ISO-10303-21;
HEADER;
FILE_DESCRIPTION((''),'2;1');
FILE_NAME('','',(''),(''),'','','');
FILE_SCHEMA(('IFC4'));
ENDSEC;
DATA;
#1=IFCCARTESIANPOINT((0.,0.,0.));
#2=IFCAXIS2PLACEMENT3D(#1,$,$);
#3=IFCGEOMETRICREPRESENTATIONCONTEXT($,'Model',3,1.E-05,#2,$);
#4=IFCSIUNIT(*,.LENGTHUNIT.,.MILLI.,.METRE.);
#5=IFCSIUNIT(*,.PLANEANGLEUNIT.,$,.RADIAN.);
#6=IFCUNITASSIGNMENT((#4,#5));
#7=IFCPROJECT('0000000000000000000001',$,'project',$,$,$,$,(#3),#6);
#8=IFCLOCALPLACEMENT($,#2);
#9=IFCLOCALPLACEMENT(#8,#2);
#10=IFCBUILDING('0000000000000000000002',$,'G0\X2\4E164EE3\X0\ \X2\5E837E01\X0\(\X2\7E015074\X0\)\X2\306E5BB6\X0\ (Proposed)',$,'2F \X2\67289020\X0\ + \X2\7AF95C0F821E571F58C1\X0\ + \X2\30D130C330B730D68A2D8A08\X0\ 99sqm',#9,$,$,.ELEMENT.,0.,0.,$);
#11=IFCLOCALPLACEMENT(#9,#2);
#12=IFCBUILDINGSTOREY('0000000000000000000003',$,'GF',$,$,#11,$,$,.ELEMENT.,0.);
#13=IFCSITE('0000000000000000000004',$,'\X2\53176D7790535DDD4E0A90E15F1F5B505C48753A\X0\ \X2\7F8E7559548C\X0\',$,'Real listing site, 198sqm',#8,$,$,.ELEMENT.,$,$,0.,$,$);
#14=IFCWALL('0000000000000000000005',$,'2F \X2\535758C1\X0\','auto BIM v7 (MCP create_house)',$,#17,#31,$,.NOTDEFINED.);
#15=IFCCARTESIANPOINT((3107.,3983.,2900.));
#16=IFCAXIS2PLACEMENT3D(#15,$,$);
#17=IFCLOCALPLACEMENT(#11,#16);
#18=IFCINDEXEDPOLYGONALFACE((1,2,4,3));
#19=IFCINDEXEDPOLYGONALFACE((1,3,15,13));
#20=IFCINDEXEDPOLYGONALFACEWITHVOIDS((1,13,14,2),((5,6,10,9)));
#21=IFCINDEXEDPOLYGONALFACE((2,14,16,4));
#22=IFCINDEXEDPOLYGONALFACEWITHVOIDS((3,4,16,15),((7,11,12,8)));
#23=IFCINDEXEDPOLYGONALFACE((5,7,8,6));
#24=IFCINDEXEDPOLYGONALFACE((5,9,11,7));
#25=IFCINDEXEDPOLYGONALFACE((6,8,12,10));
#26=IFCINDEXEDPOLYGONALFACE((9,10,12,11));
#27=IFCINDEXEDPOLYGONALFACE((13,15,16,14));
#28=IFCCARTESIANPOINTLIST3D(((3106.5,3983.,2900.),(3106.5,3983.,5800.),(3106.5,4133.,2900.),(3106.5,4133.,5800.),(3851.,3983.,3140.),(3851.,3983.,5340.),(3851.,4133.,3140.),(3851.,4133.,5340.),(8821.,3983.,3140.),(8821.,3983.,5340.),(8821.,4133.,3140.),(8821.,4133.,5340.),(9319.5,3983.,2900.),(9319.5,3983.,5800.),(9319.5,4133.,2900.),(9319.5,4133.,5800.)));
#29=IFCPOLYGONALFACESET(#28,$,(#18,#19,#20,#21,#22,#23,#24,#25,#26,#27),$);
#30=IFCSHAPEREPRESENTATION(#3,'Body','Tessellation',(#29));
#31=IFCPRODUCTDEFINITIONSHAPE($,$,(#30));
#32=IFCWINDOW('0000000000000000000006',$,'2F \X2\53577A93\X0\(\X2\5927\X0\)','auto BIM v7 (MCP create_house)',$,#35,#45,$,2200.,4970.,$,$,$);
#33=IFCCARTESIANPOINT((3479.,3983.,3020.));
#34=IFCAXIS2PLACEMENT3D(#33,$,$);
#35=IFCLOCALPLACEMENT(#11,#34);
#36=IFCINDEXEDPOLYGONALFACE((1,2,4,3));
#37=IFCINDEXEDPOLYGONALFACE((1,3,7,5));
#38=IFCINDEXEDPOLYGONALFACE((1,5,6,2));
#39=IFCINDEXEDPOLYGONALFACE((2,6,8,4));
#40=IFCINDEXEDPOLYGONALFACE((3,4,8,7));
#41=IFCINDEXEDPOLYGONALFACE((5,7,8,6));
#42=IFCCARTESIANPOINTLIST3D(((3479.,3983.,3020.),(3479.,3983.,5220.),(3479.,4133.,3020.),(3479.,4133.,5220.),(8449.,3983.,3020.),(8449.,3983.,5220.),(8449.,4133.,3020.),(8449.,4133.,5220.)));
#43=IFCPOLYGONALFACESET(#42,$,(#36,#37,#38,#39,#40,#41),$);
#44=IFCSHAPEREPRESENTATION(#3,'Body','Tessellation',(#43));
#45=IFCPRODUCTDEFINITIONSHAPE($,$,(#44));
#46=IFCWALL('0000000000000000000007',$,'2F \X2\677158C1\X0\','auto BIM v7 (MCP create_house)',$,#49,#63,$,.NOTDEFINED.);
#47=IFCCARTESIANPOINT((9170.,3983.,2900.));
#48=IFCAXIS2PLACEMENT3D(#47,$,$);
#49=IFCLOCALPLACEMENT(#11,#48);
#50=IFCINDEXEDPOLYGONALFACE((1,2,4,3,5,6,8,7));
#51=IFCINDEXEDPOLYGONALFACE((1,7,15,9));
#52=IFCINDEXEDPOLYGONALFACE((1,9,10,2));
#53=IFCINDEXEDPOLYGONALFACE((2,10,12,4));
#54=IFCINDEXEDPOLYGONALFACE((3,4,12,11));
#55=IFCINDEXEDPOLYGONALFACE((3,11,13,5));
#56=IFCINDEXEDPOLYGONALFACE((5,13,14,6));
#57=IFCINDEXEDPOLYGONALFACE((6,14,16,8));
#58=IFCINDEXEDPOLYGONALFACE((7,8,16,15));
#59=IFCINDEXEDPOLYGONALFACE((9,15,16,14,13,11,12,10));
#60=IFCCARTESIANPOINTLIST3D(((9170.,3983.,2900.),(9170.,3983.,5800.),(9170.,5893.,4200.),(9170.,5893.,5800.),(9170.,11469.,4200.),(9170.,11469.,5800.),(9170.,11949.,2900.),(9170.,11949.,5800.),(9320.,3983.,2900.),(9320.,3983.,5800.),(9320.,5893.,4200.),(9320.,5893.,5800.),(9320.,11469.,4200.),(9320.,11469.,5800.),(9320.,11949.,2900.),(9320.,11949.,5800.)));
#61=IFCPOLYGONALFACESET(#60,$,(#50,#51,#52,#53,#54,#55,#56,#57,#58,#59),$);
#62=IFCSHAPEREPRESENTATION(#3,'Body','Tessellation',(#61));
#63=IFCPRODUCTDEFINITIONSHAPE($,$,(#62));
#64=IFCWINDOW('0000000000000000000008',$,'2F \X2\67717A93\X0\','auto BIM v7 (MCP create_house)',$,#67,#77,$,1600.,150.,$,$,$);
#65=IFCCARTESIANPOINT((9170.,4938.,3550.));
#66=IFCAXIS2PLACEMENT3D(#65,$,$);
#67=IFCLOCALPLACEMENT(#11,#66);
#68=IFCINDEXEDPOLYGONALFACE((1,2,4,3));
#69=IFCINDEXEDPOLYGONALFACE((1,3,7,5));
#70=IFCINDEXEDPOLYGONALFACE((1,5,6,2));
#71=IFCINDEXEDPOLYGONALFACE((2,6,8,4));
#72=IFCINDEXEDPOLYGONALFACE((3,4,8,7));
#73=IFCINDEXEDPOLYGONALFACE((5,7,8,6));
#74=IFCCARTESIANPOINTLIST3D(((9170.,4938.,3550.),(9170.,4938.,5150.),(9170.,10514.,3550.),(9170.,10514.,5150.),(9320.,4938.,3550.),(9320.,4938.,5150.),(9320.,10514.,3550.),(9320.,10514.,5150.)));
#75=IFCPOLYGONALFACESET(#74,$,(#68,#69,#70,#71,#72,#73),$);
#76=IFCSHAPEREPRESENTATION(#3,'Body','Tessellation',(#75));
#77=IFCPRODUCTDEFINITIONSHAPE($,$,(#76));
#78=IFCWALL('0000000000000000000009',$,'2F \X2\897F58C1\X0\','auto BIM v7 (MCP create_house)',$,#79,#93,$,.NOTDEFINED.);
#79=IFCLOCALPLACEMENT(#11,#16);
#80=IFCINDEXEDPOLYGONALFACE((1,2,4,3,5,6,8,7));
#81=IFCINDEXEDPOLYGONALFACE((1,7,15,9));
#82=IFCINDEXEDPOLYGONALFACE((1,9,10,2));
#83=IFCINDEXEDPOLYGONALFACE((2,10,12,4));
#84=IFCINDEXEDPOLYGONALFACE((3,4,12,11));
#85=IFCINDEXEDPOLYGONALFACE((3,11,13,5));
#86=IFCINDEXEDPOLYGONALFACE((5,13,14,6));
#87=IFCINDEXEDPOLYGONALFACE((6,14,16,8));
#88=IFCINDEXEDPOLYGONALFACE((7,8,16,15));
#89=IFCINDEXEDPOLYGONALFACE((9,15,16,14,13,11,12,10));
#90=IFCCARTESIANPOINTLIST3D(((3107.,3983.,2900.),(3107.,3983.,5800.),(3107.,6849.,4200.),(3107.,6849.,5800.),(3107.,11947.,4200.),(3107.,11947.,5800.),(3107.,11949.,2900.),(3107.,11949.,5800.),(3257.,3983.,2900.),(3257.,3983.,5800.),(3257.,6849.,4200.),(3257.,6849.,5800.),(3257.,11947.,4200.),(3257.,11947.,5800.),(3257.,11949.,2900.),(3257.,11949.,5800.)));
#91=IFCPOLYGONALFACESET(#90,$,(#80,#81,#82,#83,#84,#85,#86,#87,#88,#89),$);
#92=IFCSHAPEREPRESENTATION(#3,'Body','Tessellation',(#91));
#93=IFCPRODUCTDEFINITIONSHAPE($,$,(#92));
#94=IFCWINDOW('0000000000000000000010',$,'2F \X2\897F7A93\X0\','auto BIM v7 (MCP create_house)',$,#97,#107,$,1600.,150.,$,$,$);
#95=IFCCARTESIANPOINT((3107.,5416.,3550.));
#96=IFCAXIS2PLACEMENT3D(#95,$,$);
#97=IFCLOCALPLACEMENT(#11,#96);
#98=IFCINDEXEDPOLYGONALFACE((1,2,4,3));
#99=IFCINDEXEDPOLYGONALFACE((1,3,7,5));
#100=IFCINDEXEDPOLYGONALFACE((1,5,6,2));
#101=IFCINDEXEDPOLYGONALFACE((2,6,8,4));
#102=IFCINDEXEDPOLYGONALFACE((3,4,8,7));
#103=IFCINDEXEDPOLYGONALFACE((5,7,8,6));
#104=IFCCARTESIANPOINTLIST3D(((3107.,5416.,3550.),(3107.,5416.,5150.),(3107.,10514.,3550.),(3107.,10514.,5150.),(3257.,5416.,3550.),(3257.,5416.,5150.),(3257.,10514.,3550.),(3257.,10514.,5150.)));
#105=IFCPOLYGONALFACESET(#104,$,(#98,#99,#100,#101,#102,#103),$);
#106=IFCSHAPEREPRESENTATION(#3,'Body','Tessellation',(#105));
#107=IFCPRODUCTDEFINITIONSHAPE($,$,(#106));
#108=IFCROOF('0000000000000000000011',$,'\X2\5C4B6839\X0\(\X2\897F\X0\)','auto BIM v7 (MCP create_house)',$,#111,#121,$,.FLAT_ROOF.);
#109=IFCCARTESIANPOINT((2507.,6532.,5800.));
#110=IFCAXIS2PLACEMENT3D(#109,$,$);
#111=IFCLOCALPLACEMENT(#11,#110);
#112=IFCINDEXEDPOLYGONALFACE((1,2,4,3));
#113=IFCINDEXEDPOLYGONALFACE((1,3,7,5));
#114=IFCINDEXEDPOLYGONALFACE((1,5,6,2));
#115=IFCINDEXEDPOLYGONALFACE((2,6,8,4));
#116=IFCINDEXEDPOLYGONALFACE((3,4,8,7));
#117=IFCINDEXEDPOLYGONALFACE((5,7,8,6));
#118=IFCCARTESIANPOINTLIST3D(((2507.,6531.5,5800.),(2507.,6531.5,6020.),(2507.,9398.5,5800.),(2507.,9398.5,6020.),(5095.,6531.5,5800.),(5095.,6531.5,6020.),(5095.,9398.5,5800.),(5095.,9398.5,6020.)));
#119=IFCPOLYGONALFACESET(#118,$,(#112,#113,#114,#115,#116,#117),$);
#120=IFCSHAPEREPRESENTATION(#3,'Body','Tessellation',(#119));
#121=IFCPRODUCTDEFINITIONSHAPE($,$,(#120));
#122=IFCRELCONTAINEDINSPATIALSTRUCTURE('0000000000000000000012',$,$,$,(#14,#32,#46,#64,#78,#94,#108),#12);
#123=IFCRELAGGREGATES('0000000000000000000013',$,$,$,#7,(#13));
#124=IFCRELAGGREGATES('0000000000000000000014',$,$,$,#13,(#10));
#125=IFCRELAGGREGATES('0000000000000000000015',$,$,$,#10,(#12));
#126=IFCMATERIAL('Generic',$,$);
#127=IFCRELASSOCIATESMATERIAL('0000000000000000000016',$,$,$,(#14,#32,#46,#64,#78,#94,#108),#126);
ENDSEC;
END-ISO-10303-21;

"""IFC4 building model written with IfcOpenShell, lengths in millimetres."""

from ifc_helpers import new_model, si_unit, frame, frame_2d, origin, place, context, project, spatial, rectangle, extrude, material, element, fill, save


model = new_model("IFC4")

# Units and contexts
model_context = context("Model", 3, precision=1e-05, world=origin())
ifc_project = project(units=[si_unit("LENGTHUNIT", "METRE", prefix="MILLI"), si_unit("PLANEANGLEUNIT", "RADIAN")], contexts=[model_context])

# Site, building, storey
site_placement = place(None, origin())
site = spatial("IfcSite", under=ifc_project, at=site_placement, Name="北海道川上郡弟子屈町 美留和", ObjectType="Real listing site, 198sqm", CompositionType="ELEMENT", RefElevation=0.0)
building_placement = place(site_placement, origin())
building = spatial("IfcBuilding", under=site, at=building_placement, Name="G0世代 広縁(縁側)の家 (Proposed)", ObjectType="2F 木造 + 竹小舞土壁 + パッシブ設計 99sqm", CompositionType="ELEMENT", ElevationOfRefHeight=0.0, ElevationOfTerrain=0.0)
storey_placement = place(building_placement, origin())
storey = spatial("IfcBuildingStorey", under=building, at=storey_placement, Name="GF", CompositionType="ELEMENT", Elevation=0.0)

# Shared definitions
ifc_material = material(Name="Generic")

# Walls, openings, windows
wall_1_placement = place(storey_placement, frame((3107.0, 3983.0, 2900.0)))
wall_1 = element("IfcWall", 1, at=wall_1_placement, inside=storey, material=ifc_material, Name="2F 南壁", Description="auto BIM v7 (MCP create_house)", PredefinedType="NOTDEFINED", context=model_context, shape_type="SweptSolid", body=[
    extrude(rectangle(XDim=6213.0, YDim=150.0, at=frame_2d((3106.0, 75.0))), frame((3107.0, 3983.0, 2900.0)), (0.0, 0.0, 1.0), 2900.0),
])
opening_1_placement = place(storey_placement, frame((3479.0, 3983.0, 3020.0)))
opening_1 = element("IfcOpeningElement", 2, at=opening_1_placement, cuts=wall_1, PredefinedType="NOTDEFINED", context=model_context, shape_type="SweptSolid", body=[
    extrude(rectangle(XDim=4970.0, YDim=150.0, at=frame_2d((2485.0, 75.0))), frame((3479.0, 3983.0, 3020.0)), (0.0, 0.0, 1.0), 2200.0),
])
window_1_placement = place(storey_placement, frame((3479.0, 3983.0, 3020.0)))
window_1 = element("IfcWindow", 3, at=window_1_placement, inside=storey, material=ifc_material, Name="2F 南窓(大)", Description="auto BIM v7 (MCP create_house)", OverallHeight=2200.0, OverallWidth=4970.0, context=model_context, shape_type="SweptSolid", body=[
    extrude(rectangle(XDim=4970.0, YDim=150.0, at=frame_2d((2485.0, 75.0))), frame((3479.0, 3983.0, 3020.0)), (0.0, 0.0, 1.0), 2200.0),
])
fill(opening_1, window_1)
wall_2_placement = place(storey_placement, frame((9170.0, 3983.0, 2900.0)))
wall_2 = element("IfcWall", 4, at=wall_2_placement, inside=storey, material=ifc_material, Name="2F 東壁", Description="auto BIM v7 (MCP create_house)", PredefinedType="NOTDEFINED", context=model_context, shape_type="SweptSolid", body=[
    extrude(rectangle(XDim=150.0, YDim=7966.0, at=frame_2d((75.0, 3983.0))), frame((9170.0, 3983.0, 2900.0)), (0.0, 0.0, 1.0), 2900.0),
])
opening_2_placement = place(storey_placement, frame((9170.0, 4938.0, 3550.0)))
opening_2 = element("IfcOpeningElement", 5, at=opening_2_placement, cuts=wall_2, PredefinedType="NOTDEFINED", context=model_context, shape_type="SweptSolid", body=[
    extrude(rectangle(XDim=150.0, YDim=5576.0, at=frame_2d((75.0, 2788.0))), frame((9170.0, 4938.0, 3550.0)), (0.0, 0.0, 1.0), 1600.0),
])
window_2_placement = place(storey_placement, frame((9170.0, 4938.0, 3550.0)))
window_2 = element("IfcWindow", 6, at=window_2_placement, inside=storey, material=ifc_material, Name="2F 東窓", Description="auto BIM v7 (MCP create_house)", OverallHeight=1600.0, OverallWidth=150.0, context=model_context, shape_type="SweptSolid", body=[
    extrude(rectangle(XDim=150.0, YDim=5576.0, at=frame_2d((75.0, 2788.0))), frame((9170.0, 4938.0, 3550.0)), (0.0, 0.0, 1.0), 1600.0),
])
fill(opening_2, window_2)
wall_3_placement = place(storey_placement, frame((3107.0, 3983.0, 2900.0)))
wall_3 = element("IfcWall", 7, at=wall_3_placement, inside=storey, material=ifc_material, Name="2F 西壁", Description="auto BIM v7 (MCP create_house)", PredefinedType="NOTDEFINED", context=model_context, shape_type="SweptSolid", body=[
    extrude(rectangle(XDim=150.0, YDim=7966.0, at=frame_2d((75.0, 3983.0))), frame((3107.0, 3983.0, 2900.0)), (0.0, 0.0, 1.0), 2900.0),
])
opening_3_placement = place(storey_placement, frame((3107.0, 5416.0, 3550.0)))
opening_3 = element("IfcOpeningElement", 8, at=opening_3_placement, cuts=wall_3, PredefinedType="NOTDEFINED", context=model_context, shape_type="SweptSolid", body=[
    extrude(rectangle(XDim=150.0, YDim=5098.0, at=frame_2d((75.0, 2549.0))), frame((3107.0, 5416.0, 3550.0)), (0.0, 0.0, 1.0), 1600.0),
])
window_3_placement = place(storey_placement, frame((3107.0, 5416.0, 3550.0)))
window_3 = element("IfcWindow", 9, at=window_3_placement, inside=storey, material=ifc_material, Name="2F 西窓", Description="auto BIM v7 (MCP create_house)", OverallHeight=1600.0, OverallWidth=150.0, context=model_context, shape_type="SweptSolid", body=[
    extrude(rectangle(XDim=150.0, YDim=5098.0, at=frame_2d((75.0, 2549.0))), frame((3107.0, 5416.0, 3550.0)), (0.0, 0.0, 1.0), 1600.0),
])
fill(opening_3, window_3)

# Roof
roof_1_placement = place(storey_placement, frame((2507.0, 6532.0, 5800.0)))
element("IfcRoof", 10, at=roof_1_placement, inside=storey, material=ifc_material, Name="屋根(西)", Description="auto BIM v7 (MCP create_house)", PredefinedType="FLAT_ROOF", context=model_context, shape_type="SweptSolid", body=[
    extrude(rectangle(XDim=2588.0, YDim=2867.0, at=frame_2d((1294.0, 1433.0))), frame((2507.0, 6532.0, 5800.0)), (0.0, 0.0, 1.0), 220.0),
])

save(model, "model.ifc")
